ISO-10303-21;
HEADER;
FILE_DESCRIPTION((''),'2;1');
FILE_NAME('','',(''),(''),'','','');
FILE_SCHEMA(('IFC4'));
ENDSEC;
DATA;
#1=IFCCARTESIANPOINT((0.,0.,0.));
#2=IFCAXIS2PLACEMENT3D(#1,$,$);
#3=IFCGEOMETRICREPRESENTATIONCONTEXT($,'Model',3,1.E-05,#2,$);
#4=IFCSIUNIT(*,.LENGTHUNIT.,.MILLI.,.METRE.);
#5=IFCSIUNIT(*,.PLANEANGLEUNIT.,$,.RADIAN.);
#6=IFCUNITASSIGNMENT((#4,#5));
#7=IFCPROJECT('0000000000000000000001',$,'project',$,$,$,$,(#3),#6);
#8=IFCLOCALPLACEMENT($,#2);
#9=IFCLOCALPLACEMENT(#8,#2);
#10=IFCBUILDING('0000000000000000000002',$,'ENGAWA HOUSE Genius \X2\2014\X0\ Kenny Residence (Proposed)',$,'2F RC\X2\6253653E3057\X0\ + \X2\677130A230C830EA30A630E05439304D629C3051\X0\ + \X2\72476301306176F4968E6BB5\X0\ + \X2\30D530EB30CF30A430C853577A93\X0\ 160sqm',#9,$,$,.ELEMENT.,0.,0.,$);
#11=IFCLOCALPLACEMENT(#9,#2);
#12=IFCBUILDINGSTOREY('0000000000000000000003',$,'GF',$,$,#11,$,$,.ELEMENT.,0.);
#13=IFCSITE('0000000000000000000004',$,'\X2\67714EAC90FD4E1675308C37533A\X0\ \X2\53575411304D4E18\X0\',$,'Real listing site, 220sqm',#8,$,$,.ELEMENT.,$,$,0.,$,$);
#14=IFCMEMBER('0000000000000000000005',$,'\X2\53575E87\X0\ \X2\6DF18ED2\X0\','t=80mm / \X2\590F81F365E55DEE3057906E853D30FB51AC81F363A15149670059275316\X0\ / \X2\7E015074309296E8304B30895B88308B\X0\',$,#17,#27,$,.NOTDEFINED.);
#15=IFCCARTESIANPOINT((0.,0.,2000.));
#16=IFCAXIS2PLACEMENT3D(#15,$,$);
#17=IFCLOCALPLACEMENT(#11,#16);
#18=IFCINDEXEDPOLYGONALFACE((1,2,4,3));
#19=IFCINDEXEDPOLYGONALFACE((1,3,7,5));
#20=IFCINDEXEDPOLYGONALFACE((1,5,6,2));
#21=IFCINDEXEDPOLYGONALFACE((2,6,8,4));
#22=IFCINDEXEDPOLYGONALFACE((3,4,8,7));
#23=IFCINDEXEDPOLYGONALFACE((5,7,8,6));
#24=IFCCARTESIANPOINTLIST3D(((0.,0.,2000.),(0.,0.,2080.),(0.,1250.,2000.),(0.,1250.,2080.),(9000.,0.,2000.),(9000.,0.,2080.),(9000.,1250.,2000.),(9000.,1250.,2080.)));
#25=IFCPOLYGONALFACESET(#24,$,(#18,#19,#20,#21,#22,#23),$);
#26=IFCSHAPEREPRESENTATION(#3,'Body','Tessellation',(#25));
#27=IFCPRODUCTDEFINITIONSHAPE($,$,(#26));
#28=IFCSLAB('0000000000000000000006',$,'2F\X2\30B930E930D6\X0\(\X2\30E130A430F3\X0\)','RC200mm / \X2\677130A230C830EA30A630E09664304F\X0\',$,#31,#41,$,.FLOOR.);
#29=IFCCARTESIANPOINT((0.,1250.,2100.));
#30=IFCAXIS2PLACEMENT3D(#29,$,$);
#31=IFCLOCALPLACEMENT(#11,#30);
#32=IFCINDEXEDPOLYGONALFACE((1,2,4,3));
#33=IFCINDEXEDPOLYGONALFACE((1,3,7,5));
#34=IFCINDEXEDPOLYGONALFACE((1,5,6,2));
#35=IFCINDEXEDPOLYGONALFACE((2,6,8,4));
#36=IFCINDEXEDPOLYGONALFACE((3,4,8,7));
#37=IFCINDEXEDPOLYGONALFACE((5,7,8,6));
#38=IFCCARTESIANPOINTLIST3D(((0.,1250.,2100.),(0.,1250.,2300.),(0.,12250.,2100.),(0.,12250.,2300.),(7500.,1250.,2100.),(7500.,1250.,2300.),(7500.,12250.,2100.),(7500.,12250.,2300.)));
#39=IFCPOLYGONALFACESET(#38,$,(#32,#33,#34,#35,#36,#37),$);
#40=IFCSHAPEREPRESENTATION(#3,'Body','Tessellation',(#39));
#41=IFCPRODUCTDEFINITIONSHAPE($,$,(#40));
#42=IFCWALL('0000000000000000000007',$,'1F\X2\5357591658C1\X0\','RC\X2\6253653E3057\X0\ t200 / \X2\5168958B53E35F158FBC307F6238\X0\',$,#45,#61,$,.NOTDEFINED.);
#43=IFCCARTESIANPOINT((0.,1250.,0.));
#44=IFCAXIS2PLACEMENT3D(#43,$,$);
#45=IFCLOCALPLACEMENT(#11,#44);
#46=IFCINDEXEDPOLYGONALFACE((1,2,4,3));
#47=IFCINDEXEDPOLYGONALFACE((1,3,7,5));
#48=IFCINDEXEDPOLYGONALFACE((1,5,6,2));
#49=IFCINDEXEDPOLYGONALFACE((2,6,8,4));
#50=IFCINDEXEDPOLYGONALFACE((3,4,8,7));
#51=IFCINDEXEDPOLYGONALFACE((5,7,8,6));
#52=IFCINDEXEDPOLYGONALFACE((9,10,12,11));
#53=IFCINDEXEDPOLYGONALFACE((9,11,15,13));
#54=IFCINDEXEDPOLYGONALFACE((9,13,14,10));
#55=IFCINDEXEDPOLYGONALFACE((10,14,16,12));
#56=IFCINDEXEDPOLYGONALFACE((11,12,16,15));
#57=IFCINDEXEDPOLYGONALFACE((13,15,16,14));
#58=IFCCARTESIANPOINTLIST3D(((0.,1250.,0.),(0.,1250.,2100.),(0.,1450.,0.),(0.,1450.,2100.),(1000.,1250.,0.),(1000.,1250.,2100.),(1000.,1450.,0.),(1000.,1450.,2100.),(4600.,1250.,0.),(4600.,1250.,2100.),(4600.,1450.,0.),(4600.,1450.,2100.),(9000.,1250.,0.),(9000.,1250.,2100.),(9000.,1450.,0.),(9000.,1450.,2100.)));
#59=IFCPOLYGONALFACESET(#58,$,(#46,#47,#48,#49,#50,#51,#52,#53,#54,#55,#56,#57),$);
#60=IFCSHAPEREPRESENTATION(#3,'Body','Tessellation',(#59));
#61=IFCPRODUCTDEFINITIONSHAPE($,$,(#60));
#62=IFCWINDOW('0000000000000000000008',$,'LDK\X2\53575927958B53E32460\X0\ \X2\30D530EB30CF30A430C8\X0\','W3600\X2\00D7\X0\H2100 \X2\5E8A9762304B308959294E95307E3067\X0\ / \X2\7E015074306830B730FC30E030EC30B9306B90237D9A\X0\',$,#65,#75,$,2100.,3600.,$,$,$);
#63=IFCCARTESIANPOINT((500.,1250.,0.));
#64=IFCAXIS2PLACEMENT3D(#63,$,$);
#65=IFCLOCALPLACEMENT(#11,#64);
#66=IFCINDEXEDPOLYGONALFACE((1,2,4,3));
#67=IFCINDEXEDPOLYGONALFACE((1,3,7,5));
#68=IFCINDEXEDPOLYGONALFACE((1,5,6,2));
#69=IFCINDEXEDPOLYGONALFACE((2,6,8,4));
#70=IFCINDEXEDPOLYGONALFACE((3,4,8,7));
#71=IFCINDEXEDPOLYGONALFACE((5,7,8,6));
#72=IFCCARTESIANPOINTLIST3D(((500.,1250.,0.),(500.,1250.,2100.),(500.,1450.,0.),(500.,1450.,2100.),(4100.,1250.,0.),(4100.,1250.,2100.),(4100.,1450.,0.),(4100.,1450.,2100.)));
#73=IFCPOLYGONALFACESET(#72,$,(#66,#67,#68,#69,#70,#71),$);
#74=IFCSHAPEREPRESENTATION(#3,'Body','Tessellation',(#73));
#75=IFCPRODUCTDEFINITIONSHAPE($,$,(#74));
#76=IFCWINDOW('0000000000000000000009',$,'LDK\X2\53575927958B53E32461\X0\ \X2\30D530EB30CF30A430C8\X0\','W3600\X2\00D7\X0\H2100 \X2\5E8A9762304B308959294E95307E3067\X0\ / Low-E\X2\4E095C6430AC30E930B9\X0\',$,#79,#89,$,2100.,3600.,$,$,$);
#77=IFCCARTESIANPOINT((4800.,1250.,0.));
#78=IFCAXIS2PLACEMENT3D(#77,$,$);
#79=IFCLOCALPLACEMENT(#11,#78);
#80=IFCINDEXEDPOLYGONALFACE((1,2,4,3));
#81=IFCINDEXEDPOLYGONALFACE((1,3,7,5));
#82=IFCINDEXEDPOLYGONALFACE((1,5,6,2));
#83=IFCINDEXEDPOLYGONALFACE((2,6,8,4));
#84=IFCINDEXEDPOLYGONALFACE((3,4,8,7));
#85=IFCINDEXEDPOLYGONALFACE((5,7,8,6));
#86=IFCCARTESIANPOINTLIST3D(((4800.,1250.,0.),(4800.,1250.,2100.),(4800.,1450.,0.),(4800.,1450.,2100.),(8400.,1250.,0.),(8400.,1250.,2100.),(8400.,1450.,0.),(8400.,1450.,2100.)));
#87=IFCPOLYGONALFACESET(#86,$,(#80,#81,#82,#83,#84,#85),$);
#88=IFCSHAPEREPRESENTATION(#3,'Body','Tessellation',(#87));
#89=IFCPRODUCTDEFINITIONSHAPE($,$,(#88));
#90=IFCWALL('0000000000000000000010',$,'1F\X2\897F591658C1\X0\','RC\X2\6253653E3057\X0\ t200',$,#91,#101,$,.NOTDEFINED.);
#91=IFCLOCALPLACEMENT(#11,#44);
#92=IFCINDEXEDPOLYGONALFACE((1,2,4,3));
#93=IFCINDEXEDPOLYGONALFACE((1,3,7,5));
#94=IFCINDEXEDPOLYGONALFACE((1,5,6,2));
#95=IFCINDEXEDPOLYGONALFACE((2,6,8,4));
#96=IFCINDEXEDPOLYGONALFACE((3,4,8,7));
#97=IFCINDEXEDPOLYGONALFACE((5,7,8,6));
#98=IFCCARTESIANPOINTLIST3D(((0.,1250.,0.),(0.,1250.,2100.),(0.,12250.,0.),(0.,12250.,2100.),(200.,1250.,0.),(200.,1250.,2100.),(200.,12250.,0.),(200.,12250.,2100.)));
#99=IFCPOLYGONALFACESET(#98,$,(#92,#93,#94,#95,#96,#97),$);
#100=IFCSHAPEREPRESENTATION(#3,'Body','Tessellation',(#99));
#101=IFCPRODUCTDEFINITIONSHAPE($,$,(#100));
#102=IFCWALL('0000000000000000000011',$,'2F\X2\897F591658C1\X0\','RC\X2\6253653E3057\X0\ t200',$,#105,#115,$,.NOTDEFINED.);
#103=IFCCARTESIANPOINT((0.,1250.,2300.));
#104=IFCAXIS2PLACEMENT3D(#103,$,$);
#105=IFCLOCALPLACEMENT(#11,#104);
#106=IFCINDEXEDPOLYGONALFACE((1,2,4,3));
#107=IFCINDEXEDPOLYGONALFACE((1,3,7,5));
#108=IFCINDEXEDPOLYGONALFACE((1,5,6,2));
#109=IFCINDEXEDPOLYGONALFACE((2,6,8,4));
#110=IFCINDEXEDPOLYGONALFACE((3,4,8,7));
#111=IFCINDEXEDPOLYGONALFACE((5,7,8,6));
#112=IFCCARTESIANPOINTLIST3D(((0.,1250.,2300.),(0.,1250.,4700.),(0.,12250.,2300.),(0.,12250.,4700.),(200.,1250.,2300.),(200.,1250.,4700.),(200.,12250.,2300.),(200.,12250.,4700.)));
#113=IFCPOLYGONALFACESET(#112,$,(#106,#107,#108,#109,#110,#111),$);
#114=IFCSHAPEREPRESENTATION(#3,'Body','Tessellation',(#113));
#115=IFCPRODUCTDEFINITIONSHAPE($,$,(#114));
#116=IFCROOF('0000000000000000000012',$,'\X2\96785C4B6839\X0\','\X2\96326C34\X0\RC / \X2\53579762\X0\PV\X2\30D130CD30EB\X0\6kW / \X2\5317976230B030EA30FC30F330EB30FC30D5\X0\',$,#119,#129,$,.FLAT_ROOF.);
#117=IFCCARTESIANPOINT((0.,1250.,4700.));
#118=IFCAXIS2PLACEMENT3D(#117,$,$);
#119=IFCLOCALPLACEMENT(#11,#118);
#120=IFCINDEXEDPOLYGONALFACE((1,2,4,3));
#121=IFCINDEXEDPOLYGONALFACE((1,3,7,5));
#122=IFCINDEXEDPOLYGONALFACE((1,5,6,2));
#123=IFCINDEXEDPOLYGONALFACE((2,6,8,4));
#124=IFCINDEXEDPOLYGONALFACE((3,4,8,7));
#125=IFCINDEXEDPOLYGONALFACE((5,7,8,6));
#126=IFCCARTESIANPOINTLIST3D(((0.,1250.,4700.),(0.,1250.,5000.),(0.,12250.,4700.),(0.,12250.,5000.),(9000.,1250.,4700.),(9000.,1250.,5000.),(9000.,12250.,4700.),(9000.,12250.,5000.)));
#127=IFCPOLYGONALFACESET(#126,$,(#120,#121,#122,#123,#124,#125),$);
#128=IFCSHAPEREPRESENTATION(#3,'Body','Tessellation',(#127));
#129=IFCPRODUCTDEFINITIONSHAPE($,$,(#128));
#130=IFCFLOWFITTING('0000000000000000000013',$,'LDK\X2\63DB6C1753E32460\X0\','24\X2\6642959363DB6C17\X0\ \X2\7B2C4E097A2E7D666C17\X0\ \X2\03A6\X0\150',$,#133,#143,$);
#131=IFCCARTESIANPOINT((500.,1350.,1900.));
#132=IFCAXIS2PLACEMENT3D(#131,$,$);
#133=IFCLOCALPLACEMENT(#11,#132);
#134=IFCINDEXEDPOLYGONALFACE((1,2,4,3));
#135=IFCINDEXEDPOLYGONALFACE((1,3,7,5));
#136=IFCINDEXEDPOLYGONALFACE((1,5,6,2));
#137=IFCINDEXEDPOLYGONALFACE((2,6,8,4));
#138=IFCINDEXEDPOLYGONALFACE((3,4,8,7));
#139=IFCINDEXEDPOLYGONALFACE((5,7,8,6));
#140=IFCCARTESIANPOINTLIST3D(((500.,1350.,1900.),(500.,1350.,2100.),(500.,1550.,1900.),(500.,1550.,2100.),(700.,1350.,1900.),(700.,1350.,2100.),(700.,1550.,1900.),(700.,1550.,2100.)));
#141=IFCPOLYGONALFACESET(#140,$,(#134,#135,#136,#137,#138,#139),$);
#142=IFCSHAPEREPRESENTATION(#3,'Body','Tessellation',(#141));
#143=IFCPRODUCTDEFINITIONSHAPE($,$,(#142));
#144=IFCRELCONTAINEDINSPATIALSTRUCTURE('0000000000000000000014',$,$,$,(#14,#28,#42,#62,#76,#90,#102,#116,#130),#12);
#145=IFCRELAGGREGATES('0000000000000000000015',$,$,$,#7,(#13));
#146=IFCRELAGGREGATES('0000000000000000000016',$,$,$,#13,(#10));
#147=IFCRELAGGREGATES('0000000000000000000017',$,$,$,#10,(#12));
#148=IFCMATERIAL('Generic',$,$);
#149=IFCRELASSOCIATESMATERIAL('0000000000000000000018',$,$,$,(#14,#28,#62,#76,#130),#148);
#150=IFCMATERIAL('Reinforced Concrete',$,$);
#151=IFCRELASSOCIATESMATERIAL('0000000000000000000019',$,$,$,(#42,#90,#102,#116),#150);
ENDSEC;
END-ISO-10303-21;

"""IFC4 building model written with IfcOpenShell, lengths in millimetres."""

from ifc_helpers import new_model, si_unit, frame, frame_2d, origin, place, context, project, spatial, rectangle, extrude, material, element, fill, save


model = new_model("IFC4")

# Units and contexts
model_context = context("Model", 3, precision=1e-05, world=origin())
ifc_project = project(units=[si_unit("LENGTHUNIT", "METRE", prefix="MILLI"), si_unit("PLANEANGLEUNIT", "RADIAN")], contexts=[model_context])

# Site, building, storey
site_placement = place(None, origin())
site = spatial("IfcSite", under=ifc_project, at=site_placement, Name="東京都世田谷区 南向き丘", ObjectType="Real listing site, 220sqm", CompositionType="ELEMENT", RefElevation=0.0)
building_placement = place(site_placement, origin())
building = spatial("IfcBuilding", under=site, at=building_placement, Name="ENGAWA HOUSE Genius — Kenny Residence (Proposed)", ObjectType="2F RC打放し + 東アトリウム吹き抜け + 片持ち直階段 + フルハイト南窓 160sqm", CompositionType="ELEMENT", ElevationOfRefHeight=0.0, ElevationOfTerrain=0.0)
storey_placement = place(building_placement, origin())
storey = spatial("IfcBuildingStorey", under=building, at=storey_placement, Name="GF", CompositionType="ELEMENT", Elevation=0.0)

# Member
ifc_material_1 = material(Name="Generic")
member_placement = place(storey_placement, frame((0.0, 0.0, 2000.0)))
element("IfcMember", 1, at=member_placement, inside=storey, material=ifc_material_1, Name="南庇 深軒", Description="t=80mm / 夏至日差し遮蔽・冬至採光最大化 / 縁側を雨から守る", PredefinedType="NOTDEFINED", context=model_context, shape_type="SweptSolid", body=[
    extrude(rectangle(XDim=9000.0, YDim=1250.0, at=frame_2d((4500.0, 625.0))), frame((0.0, 0.0, 2000.0)), (0.0, 0.0, 1.0), 80.0),
])

# Slab
ifc_material_2 = material(Name="Reinforced Concrete")
slab_1_placement = place(storey_placement, frame((0.0, 1250.0, 2100.0)))
element("IfcSlab", 2, at=slab_1_placement, inside=storey, material=ifc_material_1, Name="2Fスラブ(メイン)", Description="RC200mm / 東アトリウム除く", PredefinedType="FLOOR", context=model_context, shape_type="SweptSolid", body=[
    extrude(rectangle(XDim=7500.0, YDim=11000.0, at=frame_2d((3750.0, 5500.0))), frame((0.0, 1250.0, 2100.0)), (0.0, 0.0, 1.0), 200.0),
])

# Wall, openings, windows
wall_1_placement = place(storey_placement, frame((0.0, 1250.0, 0.0)))
wall_1 = element("IfcWall", 3, at=wall_1_placement, inside=storey, material=ifc_material_2, Name="1F南外壁", Description="RC打放し t200 / 全開口引込み戸", PredefinedType="NOTDEFINED", context=model_context, shape_type="SweptSolid", body=[
    extrude(rectangle(XDim=9000.0, YDim=200.0, at=frame_2d((4500.0, 100.0))), frame((0.0, 1250.0, 0.0)), (0.0, 0.0, 1.0), 2100.0),
])
opening_1_placement = place(storey_placement, frame((500.0, 1250.0, 0.0)))
opening_1 = element("IfcOpeningElement", 4, at=opening_1_placement, cuts=wall_1, PredefinedType="NOTDEFINED", context=model_context, shape_type="SweptSolid", body=[
    extrude(rectangle(XDim=3600.0, YDim=200.0, at=frame_2d((1800.0, 100.0))), frame((500.0, 1250.0, 0.0)), (0.0, 0.0, 1.0), 2100.0),
])
opening_2_placement = place(storey_placement, frame((4800.0, 1250.0, 0.0)))
opening_2 = element("IfcOpeningElement", 5, at=opening_2_placement, cuts=wall_1, PredefinedType="NOTDEFINED", context=model_context, shape_type="SweptSolid", body=[
    extrude(rectangle(XDim=3600.0, YDim=200.0, at=frame_2d((1800.0, 100.0))), frame((4800.0, 1250.0, 0.0)), (0.0, 0.0, 1.0), 2100.0),
])
window_1_placement = place(storey_placement, frame((500.0, 1250.0, 0.0)))
window_1 = element("IfcWindow", 6, at=window_1_placement, inside=storey, material=ifc_material_1, Name="LDK南大開口① フルハイト", Description="W3600×H2100 床面から天井まで / 縁側とシームレスに連続", OverallHeight=2100.0, OverallWidth=3600.0, context=model_context, shape_type="SweptSolid", body=[
    extrude(rectangle(XDim=3600.0, YDim=200.0, at=frame_2d((1800.0, 100.0))), frame((500.0, 1250.0, 0.0)), (0.0, 0.0, 1.0), 2100.0),
])
fill(opening_1, window_1)
window_2_placement = place(storey_placement, frame((4800.0, 1250.0, 0.0)))
window_2 = element("IfcWindow", 7, at=window_2_placement, inside=storey, material=ifc_material_1, Name="LDK南大開口② フルハイト", Description="W3600×H2100 床面から天井まで / Low-E三層ガラス", OverallHeight=2100.0, OverallWidth=3600.0, context=model_context, shape_type="SweptSolid", body=[
    extrude(rectangle(XDim=3600.0, YDim=200.0, at=frame_2d((1800.0, 100.0))), frame((4800.0, 1250.0, 0.0)), (0.0, 0.0, 1.0), 2100.0),
])
fill(opening_2, window_2)

# Wall
wall_2_placement = place(storey_placement, frame((0.0, 1250.0, 0.0)))
element("IfcWall", 8, at=wall_2_placement, inside=storey, material=ifc_material_2, Name="1F西外壁", Description="RC打放し t200", PredefinedType="NOTDEFINED", context=model_context, shape_type="SweptSolid", body=[
    extrude(rectangle(XDim=200.0, YDim=11000.0, at=frame_2d((100.0, 5500.0))), frame((0.0, 1250.0, 0.0)), (0.0, 0.0, 1.0), 2100.0),
])

# Wall
wall_3_placement = place(storey_placement, frame((0.0, 1250.0, 2300.0)))
element("IfcWall", 9, at=wall_3_placement, inside=storey, material=ifc_material_2, Name="2F西外壁", Description="RC打放し t200", PredefinedType="NOTDEFINED", context=model_context, shape_type="SweptSolid", body=[
    extrude(rectangle(XDim=200.0, YDim=11000.0, at=frame_2d((100.0, 5500.0))), frame((0.0, 1250.0, 2300.0)), (0.0, 0.0, 1.0), 2400.0),
])

# Roof
roof_placement = place(storey_placement, frame((0.0, 1250.0, 4700.0)))
element("IfcRoof", 10, at=roof_placement, inside=storey, material=ifc_material_2, Name="陸屋根", Description="防水RC / 南面PVパネル6kW / 北面グリーンルーフ", PredefinedType="FLAT_ROOF", context=model_context, shape_type="SweptSolid", body=[
    extrude(rectangle(XDim=9000.0, YDim=11000.0, at=frame_2d((4500.0, 5500.0))), frame((0.0, 1250.0, 4700.0)), (0.0, 0.0, 1.0), 300.0),
])

# Flow fitting
flow_fitting_placement = place(storey_placement, frame((500.0, 1350.0, 1900.0)))
element("IfcFlowFitting", 11, at=flow_fitting_placement, inside=storey, material=ifc_material_1, Name="LDK換気口①", Description="24時間換気 第三種給気 Φ150", context=model_context, shape_type="SweptSolid", body=[
    extrude(rectangle(XDim=200.0, YDim=200.0, at=frame_2d((100.0, 100.0))), frame((500.0, 1350.0, 1900.0)), (0.0, 0.0, 1.0), 200.0),
])

save(model, "model.ifc")
